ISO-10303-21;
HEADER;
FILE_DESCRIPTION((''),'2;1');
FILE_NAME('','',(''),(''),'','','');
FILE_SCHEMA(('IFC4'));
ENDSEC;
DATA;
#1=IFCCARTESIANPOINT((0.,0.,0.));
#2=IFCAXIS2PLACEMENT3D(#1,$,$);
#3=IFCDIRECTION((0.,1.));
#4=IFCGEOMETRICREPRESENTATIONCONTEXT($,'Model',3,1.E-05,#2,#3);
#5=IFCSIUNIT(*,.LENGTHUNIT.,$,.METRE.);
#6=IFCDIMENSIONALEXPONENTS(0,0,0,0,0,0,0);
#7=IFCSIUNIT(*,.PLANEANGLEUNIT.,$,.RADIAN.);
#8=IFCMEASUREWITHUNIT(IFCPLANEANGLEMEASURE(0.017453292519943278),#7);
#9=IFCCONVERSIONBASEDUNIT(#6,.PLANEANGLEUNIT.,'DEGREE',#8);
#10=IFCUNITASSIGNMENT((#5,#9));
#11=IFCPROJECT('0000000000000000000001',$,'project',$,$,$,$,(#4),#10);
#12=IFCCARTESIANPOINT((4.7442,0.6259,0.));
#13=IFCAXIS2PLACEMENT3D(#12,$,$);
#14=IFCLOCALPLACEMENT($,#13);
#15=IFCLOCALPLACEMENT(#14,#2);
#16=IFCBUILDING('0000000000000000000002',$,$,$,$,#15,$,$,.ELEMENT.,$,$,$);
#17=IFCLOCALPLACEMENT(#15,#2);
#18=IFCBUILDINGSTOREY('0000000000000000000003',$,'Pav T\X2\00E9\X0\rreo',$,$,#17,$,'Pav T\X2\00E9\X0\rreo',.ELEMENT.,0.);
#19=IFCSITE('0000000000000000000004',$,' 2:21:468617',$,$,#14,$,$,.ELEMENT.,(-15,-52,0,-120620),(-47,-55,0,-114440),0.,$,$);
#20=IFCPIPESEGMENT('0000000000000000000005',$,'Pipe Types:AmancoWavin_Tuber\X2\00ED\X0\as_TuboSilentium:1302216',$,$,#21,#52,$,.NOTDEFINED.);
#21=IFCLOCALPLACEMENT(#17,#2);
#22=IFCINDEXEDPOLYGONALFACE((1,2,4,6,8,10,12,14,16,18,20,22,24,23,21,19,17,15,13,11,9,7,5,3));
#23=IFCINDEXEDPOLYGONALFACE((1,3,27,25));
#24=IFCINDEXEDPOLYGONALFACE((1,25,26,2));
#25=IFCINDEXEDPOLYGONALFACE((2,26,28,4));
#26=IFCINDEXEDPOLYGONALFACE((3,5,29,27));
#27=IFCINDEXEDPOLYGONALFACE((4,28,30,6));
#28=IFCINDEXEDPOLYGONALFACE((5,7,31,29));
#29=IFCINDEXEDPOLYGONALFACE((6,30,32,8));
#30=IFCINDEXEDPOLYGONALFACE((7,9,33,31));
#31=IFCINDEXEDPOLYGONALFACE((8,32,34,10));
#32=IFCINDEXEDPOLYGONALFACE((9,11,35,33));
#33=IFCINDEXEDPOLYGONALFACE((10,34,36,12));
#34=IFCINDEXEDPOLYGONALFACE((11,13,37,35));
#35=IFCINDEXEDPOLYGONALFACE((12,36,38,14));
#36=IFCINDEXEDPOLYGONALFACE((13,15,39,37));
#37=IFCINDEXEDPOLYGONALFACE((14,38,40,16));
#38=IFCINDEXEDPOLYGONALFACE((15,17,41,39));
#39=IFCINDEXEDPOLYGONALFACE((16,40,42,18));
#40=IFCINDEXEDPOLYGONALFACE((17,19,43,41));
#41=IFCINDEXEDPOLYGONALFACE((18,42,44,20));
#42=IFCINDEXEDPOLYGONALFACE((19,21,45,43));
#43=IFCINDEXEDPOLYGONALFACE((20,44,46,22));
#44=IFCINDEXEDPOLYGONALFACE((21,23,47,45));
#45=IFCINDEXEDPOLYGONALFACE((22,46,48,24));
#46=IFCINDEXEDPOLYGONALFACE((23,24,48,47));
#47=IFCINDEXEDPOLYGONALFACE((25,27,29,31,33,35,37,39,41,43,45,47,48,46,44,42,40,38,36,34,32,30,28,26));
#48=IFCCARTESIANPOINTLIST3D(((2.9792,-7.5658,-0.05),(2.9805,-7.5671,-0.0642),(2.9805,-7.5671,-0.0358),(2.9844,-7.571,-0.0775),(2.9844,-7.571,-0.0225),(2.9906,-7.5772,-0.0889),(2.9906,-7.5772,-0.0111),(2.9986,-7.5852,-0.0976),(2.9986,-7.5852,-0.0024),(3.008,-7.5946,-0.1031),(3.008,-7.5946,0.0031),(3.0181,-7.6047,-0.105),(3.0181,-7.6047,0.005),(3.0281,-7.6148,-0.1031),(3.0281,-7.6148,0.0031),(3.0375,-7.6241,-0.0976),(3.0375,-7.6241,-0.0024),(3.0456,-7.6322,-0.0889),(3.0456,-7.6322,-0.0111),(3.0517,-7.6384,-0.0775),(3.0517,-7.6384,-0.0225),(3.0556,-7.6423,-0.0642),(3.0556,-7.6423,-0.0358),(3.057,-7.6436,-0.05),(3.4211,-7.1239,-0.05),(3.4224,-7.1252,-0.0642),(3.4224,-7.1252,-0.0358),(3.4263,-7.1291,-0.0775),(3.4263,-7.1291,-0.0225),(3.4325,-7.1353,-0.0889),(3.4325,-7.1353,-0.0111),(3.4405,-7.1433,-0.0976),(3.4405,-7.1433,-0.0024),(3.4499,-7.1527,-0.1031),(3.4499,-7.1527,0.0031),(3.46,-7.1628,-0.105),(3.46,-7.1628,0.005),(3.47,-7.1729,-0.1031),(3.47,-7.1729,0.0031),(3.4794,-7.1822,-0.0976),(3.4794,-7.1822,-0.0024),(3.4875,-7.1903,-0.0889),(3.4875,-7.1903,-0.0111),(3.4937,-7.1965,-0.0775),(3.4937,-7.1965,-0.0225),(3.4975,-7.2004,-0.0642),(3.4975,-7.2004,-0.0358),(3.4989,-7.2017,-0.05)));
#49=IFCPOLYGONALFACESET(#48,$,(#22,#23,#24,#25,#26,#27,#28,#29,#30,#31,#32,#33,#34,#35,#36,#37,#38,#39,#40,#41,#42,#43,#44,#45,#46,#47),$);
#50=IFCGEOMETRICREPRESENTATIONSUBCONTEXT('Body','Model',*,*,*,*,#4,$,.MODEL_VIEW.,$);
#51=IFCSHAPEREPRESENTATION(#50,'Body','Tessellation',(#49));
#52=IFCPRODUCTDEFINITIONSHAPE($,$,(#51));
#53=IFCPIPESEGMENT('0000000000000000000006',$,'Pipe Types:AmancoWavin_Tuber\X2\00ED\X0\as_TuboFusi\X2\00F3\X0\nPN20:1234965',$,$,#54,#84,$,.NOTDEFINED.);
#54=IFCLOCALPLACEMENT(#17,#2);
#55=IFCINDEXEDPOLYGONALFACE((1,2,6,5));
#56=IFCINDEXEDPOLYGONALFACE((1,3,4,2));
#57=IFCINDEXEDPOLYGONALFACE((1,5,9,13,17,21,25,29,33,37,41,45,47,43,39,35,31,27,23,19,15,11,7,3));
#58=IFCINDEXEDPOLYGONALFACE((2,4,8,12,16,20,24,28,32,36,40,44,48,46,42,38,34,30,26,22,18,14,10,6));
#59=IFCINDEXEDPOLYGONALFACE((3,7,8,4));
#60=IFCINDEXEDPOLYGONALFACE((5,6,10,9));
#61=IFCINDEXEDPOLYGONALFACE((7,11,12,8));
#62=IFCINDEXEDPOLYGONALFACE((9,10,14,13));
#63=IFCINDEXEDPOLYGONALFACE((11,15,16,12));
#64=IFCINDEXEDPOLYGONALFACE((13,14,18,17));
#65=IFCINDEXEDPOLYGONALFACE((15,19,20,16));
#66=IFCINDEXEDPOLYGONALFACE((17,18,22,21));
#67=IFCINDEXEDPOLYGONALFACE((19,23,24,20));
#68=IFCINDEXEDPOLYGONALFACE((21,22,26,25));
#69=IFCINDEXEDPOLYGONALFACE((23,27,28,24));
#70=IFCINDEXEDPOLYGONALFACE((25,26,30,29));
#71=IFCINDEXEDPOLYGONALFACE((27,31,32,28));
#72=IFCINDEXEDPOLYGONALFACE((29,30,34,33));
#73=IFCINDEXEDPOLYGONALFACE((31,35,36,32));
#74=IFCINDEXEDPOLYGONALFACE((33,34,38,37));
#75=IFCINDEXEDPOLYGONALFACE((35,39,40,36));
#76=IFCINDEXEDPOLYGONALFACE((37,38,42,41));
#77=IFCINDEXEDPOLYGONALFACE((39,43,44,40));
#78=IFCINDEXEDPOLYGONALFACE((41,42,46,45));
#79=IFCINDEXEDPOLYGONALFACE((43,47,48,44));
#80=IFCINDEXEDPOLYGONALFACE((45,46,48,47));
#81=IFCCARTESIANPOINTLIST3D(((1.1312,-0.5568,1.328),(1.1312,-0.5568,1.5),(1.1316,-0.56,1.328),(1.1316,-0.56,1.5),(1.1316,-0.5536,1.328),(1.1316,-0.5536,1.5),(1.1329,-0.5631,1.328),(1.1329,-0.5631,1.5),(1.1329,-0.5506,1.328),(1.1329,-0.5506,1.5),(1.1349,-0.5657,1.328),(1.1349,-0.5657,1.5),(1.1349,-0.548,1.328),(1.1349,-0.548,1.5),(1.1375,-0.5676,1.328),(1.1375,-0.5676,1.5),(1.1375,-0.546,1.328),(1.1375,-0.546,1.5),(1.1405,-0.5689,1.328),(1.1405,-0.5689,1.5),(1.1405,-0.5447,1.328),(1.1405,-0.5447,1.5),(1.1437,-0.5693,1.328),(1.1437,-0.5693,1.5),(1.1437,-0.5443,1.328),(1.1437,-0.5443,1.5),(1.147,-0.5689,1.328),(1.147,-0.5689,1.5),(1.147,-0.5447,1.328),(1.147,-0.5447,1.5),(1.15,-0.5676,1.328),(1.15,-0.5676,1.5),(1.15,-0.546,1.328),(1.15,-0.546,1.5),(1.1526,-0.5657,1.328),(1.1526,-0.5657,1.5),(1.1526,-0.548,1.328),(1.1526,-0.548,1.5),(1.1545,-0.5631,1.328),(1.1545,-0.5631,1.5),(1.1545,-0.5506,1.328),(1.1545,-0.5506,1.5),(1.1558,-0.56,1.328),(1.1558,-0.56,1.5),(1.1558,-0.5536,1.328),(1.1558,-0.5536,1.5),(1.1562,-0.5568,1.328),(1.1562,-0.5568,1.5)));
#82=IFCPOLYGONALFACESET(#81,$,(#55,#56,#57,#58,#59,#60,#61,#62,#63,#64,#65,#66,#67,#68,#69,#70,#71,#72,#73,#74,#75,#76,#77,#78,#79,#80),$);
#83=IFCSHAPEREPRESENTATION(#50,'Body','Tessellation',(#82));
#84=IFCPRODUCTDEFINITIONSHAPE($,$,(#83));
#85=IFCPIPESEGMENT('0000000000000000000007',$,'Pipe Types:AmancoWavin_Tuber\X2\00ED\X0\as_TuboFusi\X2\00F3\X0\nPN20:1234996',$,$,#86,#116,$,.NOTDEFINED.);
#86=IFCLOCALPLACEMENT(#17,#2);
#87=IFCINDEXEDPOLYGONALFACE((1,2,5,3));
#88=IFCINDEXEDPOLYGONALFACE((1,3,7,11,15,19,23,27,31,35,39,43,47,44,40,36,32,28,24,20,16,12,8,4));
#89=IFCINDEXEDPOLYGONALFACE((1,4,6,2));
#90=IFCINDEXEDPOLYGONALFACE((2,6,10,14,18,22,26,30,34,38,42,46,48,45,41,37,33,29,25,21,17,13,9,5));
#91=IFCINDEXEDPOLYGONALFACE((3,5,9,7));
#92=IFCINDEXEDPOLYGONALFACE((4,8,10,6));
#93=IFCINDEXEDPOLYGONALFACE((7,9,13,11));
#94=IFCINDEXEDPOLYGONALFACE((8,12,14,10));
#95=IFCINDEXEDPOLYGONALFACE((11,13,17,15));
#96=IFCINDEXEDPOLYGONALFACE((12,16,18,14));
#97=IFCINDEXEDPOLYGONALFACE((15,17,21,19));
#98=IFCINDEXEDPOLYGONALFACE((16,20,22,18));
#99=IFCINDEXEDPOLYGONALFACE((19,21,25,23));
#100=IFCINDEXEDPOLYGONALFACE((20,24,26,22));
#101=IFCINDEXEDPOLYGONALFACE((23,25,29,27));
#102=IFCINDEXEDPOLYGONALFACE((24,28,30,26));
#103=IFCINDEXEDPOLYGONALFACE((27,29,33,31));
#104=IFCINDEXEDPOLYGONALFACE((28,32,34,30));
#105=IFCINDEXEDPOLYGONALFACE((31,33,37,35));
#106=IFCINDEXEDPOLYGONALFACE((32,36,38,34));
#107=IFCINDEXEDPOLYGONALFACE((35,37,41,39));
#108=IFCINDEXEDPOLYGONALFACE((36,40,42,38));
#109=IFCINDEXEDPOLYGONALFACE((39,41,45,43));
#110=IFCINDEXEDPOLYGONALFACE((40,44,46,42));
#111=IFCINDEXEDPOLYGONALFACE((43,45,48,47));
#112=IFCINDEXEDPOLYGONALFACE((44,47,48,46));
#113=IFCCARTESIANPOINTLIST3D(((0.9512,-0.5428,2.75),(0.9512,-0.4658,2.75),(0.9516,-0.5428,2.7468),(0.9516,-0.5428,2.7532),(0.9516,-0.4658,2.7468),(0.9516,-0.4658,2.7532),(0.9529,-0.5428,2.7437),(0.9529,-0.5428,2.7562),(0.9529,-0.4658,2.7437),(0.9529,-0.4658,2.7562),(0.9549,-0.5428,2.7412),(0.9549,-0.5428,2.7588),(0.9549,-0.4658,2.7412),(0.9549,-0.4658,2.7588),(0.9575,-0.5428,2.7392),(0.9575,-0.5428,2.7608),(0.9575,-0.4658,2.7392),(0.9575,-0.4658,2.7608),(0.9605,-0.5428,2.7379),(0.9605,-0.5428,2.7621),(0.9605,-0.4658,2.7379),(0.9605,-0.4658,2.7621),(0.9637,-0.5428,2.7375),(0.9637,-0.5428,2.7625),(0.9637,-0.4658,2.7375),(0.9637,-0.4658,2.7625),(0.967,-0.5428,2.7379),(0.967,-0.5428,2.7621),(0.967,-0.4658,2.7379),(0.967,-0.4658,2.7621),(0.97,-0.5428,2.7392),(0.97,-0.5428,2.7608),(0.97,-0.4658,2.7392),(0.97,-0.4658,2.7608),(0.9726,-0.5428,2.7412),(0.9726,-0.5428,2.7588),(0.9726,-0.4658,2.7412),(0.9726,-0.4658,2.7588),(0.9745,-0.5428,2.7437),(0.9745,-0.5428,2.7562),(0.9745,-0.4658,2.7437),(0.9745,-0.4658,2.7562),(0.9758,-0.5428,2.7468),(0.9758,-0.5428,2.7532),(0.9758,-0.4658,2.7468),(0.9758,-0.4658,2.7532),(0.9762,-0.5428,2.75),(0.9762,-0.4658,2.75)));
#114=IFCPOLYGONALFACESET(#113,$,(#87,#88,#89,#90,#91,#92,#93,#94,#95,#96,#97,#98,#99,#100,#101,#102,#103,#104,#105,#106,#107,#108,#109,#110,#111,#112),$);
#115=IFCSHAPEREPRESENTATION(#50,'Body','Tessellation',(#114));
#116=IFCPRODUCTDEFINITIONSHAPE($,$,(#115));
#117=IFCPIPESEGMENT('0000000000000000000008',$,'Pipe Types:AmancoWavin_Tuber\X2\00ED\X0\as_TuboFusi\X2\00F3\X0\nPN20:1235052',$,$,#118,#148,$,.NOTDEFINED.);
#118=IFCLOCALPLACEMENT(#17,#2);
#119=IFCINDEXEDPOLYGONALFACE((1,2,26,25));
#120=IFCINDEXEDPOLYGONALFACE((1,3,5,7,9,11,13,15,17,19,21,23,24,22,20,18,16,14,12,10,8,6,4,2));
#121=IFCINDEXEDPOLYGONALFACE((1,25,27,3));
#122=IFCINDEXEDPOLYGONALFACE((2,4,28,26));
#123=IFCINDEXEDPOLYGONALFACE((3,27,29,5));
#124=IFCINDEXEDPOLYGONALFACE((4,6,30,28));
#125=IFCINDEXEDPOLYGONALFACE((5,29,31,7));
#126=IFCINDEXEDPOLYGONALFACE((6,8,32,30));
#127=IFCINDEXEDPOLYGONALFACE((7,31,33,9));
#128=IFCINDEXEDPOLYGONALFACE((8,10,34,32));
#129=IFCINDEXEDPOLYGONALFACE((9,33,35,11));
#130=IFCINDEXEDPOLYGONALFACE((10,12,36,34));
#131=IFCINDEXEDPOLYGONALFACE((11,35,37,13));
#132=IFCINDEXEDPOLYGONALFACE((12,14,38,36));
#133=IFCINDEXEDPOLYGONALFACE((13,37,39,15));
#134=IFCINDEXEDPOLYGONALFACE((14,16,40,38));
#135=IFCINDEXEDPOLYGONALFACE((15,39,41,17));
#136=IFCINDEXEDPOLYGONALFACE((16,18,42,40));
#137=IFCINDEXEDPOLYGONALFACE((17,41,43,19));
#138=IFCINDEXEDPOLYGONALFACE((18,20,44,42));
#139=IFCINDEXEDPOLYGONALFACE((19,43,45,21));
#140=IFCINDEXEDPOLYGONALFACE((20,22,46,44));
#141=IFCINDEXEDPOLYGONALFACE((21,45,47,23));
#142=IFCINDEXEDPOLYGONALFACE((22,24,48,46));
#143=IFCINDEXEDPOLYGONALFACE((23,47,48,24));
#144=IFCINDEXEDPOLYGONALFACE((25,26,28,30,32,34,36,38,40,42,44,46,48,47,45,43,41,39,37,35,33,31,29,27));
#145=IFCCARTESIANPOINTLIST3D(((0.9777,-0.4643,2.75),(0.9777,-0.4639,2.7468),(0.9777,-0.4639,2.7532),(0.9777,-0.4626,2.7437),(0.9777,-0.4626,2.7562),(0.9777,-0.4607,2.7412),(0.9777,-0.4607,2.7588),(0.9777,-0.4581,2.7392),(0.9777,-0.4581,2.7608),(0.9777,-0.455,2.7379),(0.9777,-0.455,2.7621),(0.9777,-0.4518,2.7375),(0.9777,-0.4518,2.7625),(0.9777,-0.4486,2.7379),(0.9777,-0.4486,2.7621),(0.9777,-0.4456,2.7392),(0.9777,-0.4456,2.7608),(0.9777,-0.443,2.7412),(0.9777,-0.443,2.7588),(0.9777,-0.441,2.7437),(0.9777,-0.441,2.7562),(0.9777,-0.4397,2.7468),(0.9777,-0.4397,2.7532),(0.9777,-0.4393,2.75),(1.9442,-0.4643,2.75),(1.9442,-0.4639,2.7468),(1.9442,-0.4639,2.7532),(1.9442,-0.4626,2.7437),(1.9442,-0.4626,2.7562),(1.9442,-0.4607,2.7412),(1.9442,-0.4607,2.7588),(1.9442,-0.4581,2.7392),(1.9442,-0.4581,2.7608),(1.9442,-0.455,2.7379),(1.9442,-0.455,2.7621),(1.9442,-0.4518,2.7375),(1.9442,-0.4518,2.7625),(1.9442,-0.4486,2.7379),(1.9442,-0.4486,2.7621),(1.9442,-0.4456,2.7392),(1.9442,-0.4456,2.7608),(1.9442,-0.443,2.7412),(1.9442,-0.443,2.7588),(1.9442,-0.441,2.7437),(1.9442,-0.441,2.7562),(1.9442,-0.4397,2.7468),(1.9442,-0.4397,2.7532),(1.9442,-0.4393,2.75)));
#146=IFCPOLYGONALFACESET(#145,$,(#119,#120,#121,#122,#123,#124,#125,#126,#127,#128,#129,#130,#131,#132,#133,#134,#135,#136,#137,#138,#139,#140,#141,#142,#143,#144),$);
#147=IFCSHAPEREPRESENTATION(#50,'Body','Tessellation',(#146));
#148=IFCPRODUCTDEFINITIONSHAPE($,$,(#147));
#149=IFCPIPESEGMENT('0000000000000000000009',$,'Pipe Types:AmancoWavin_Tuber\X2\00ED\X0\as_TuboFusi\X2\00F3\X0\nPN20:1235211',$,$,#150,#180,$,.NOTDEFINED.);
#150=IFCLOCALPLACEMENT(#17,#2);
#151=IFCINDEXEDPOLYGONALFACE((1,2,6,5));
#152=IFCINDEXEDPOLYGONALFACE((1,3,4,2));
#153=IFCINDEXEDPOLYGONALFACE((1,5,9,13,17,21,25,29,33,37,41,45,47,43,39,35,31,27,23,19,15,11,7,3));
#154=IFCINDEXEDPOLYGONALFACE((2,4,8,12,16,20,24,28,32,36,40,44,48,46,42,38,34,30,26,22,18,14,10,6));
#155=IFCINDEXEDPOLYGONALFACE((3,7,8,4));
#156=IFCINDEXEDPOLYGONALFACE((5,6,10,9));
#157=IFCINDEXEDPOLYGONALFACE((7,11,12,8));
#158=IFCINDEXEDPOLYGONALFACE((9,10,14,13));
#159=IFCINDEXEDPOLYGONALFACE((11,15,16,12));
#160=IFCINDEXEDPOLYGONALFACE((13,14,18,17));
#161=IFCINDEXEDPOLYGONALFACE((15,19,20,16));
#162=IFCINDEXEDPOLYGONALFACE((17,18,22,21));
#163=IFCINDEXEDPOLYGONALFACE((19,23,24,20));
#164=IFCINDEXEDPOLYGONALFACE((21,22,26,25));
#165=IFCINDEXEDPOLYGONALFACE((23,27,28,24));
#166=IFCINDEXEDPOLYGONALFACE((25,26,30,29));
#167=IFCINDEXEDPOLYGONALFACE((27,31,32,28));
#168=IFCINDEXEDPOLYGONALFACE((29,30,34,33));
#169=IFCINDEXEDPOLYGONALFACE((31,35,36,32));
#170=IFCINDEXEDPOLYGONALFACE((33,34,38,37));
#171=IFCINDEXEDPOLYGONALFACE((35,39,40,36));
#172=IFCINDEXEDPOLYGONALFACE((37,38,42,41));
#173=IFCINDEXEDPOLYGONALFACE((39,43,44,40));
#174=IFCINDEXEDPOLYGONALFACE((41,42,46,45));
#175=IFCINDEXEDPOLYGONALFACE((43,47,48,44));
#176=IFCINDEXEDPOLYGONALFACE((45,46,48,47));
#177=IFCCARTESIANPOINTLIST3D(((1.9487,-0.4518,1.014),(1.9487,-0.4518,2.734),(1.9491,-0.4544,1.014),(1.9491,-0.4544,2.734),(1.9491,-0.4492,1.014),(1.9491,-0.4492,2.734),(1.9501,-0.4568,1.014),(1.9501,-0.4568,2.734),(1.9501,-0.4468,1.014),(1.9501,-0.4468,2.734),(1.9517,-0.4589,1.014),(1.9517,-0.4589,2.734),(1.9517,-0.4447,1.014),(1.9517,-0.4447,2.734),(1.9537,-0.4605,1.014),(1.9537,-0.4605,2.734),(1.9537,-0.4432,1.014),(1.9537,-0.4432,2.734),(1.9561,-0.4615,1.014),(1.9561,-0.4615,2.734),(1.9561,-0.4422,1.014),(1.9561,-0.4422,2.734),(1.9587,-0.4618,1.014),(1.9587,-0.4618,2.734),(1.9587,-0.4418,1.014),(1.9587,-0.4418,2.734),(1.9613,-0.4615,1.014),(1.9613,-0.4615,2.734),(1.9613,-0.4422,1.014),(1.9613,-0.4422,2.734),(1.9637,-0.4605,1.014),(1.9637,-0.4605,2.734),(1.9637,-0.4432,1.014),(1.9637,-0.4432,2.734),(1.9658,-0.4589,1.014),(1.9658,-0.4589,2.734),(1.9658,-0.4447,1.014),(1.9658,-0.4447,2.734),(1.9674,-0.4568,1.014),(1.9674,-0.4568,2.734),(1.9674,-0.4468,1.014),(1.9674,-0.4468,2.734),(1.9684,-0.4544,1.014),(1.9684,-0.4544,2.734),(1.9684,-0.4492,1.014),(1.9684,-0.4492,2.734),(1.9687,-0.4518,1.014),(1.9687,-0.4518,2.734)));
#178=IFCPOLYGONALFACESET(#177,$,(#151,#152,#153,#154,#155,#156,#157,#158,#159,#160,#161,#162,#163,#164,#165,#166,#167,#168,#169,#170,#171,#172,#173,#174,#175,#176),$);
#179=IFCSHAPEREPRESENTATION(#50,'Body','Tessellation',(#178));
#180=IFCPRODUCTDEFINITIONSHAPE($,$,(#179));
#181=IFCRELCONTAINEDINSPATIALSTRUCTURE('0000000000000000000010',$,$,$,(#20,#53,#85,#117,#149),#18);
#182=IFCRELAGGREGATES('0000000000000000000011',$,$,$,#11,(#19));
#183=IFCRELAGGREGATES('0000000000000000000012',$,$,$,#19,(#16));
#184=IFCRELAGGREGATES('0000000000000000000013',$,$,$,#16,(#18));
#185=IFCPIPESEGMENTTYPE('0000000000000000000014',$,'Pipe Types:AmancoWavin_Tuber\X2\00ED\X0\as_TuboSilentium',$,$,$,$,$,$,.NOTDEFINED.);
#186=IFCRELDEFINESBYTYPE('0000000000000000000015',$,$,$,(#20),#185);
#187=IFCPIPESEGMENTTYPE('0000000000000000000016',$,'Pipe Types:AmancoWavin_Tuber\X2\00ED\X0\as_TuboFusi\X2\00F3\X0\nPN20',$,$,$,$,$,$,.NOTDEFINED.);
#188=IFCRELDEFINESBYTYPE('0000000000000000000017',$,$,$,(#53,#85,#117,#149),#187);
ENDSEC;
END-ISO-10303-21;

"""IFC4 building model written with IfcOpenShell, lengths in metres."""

from ifc_helpers import new_model, entity, si_unit, converted_unit, direction, frame, origin, place, context, subcontext, project, spatial, arc, indexed_curve, outline, extrude, type_object, element, save


model = new_model("IFC4")

# Units and contexts
model_context = context("Model", 3, precision=1e-05, world=origin(), true_north=direction((0.0, 1.0)))
body_context = subcontext(model_context, "Body", "Model", "MODEL_VIEW")
ifc_project = project(units=[si_unit("LENGTHUNIT", "METRE"), converted_unit("PLANEANGLEUNIT", "DEGREE", entity("IfcPlaneAngleMeasure", 0.017453292519943278), si_unit("PLANEANGLEUNIT", "RADIAN"), dimensions=[0, 0, 0, 0, 0, 0, 0])], contexts=[model_context])

# Site, building, storey
site_placement = place(None, frame((4.7442, 0.6259, 0.0)))
site = spatial("IfcSite", under=ifc_project, at=site_placement, Name=" 2:21:468617", CompositionType="ELEMENT", RefLatitude=(-15, -52, 0, -120620), RefLongitude=(-47, -55, 0, -114440), RefElevation=0.0)
building_placement = place(site_placement, origin())
building = spatial("IfcBuilding", under=site, at=building_placement, CompositionType="ELEMENT")
storey_placement = place(building_placement, origin())
storey = spatial("IfcBuildingStorey", under=building, at=storey_placement, Name="Pav Térreo", LongName="Pav Térreo", CompositionType="ELEMENT", Elevation=0.0)

# Pipe segments
pipe_segment_type_1 = type_object("IfcPipeSegmentType", Name="Pipe Types:AmancoWavin_Tuberías_TuboSilentium", PredefinedType="NOTDEFINED")
pipe_segment_1_placement = place(storey_placement, origin())
element("IfcPipeSegment", 1, at=pipe_segment_1_placement, inside=storey, type_object=pipe_segment_type_1, Name="Pipe Types:AmancoWavin_Tuberías_TuboSilentium:1302216", PredefinedType="NOTDEFINED", context=body_context, shape_type="SweptSolid", body=[
    extrude(outline(indexed_curve([(0.055, 0.0), (0.0389, 0.0389), (0.0, 0.055), (-0.0389, 0.0389), (-0.055, 0.0), (-0.0389, -0.0389), (0.0, -0.055), (0.0389, -0.0389)], segments=[arc(1, 2, 3), arc(3, 4, 5), arc(5, 6, 7), arc(7, 8, 1)], self_intersect=False)), frame((3.0181, -7.6047, -0.05), z_axis=(0.707107, 0.707107, 0.0), x_axis=(0.707107, -0.707107, 0.0)), (0.0, 0.0, 1.0), 0.6249),
])
pipe_segment_type_2 = type_object("IfcPipeSegmentType", Name="Pipe Types:AmancoWavin_Tuberías_TuboFusiónPN20", PredefinedType="NOTDEFINED")
pipe_segment_2_placement = place(storey_placement, origin())
element("IfcPipeSegment", 2, at=pipe_segment_2_placement, inside=storey, type_object=pipe_segment_type_2, Name="Pipe Types:AmancoWavin_Tuberías_TuboFusiónPN20:1234965", PredefinedType="NOTDEFINED", context=body_context, shape_type="SweptSolid", body=[
    extrude(outline(indexed_curve([(0.0125, 0.0), (0.0088, 0.0088), (0.0, 0.0125), (-0.0088, 0.0088), (-0.0125, 0.0), (-0.0088, -0.0088), (0.0, -0.0125), (0.0088, -0.0088)], segments=[arc(1, 2, 3), arc(3, 4, 5), arc(5, 6, 7), arc(7, 8, 1)], self_intersect=False)), frame((1.1437, -0.5568, 1.328), z_axis=(0.0, 0.0, 1.0), x_axis=(-1.0, 0.0, 0.0)), (0.0, 0.0, 1.0), 0.172),
])
pipe_segment_3_placement = place(storey_placement, origin())
element("IfcPipeSegment", 3, at=pipe_segment_3_placement, inside=storey, type_object=pipe_segment_type_2, Name="Pipe Types:AmancoWavin_Tuberías_TuboFusiónPN20:1234996", PredefinedType="NOTDEFINED", context=body_context, shape_type="SweptSolid", body=[
    extrude(outline(indexed_curve([(0.0125, 0.0), (0.0088, 0.0088), (0.0, 0.0125), (-0.0088, 0.0088), (-0.0125, 0.0), (-0.0088, -0.0088), (0.0, -0.0125), (0.0088, -0.0088)], segments=[arc(1, 2, 3), arc(3, 4, 5), arc(5, 6, 7), arc(7, 8, 1)], self_intersect=False)), frame((0.9637, -0.5428, 2.75), z_axis=(0.0, 1.0, 0.0), x_axis=(1.0, 0.0, 0.0)), (0.0, 0.0, 1.0), 0.077),
])
pipe_segment_4_placement = place(storey_placement, origin())
element("IfcPipeSegment", 4, at=pipe_segment_4_placement, inside=storey, type_object=pipe_segment_type_2, Name="Pipe Types:AmancoWavin_Tuberías_TuboFusiónPN20:1235052", PredefinedType="NOTDEFINED", context=body_context, shape_type="SweptSolid", body=[
    extrude(outline(indexed_curve([(0.0125, 0.0), (0.0088, 0.0088), (0.0, 0.0125), (-0.0088, 0.0088), (-0.0125, 0.0), (-0.0088, -0.0088), (0.0, -0.0125), (0.0088, -0.0088)], segments=[arc(1, 2, 3), arc(3, 4, 5), arc(5, 6, 7), arc(7, 8, 1)], self_intersect=False)), frame((0.9777, -0.4518, 2.75), z_axis=(1.0, 0.0, 0.0), x_axis=(0.0, -1.0, 0.0)), (0.0, 0.0, 1.0), 0.9665),
])
pipe_segment_5_placement = place(storey_placement, origin())
element("IfcPipeSegment", 5, at=pipe_segment_5_placement, inside=storey, type_object=pipe_segment_type_2, Name="Pipe Types:AmancoWavin_Tuberías_TuboFusiónPN20:1235211", PredefinedType="NOTDEFINED", context=body_context, shape_type="SweptSolid", body=[
    extrude(outline(indexed_curve([(0.01, 0.0), (0.0071, 0.0071), (0.0, 0.01), (-0.0071, 0.0071), (-0.01, 0.0), (-0.0071, -0.0071), (0.0, -0.01), (0.0071, -0.0071)], segments=[arc(1, 2, 3), arc(3, 4, 5), arc(5, 6, 7), arc(7, 8, 1)], self_intersect=False)), frame((1.9587, -0.4518, 1.014)), (0.0, 0.0, 1.0), 1.72),
])

save(model, "model.ifc")
